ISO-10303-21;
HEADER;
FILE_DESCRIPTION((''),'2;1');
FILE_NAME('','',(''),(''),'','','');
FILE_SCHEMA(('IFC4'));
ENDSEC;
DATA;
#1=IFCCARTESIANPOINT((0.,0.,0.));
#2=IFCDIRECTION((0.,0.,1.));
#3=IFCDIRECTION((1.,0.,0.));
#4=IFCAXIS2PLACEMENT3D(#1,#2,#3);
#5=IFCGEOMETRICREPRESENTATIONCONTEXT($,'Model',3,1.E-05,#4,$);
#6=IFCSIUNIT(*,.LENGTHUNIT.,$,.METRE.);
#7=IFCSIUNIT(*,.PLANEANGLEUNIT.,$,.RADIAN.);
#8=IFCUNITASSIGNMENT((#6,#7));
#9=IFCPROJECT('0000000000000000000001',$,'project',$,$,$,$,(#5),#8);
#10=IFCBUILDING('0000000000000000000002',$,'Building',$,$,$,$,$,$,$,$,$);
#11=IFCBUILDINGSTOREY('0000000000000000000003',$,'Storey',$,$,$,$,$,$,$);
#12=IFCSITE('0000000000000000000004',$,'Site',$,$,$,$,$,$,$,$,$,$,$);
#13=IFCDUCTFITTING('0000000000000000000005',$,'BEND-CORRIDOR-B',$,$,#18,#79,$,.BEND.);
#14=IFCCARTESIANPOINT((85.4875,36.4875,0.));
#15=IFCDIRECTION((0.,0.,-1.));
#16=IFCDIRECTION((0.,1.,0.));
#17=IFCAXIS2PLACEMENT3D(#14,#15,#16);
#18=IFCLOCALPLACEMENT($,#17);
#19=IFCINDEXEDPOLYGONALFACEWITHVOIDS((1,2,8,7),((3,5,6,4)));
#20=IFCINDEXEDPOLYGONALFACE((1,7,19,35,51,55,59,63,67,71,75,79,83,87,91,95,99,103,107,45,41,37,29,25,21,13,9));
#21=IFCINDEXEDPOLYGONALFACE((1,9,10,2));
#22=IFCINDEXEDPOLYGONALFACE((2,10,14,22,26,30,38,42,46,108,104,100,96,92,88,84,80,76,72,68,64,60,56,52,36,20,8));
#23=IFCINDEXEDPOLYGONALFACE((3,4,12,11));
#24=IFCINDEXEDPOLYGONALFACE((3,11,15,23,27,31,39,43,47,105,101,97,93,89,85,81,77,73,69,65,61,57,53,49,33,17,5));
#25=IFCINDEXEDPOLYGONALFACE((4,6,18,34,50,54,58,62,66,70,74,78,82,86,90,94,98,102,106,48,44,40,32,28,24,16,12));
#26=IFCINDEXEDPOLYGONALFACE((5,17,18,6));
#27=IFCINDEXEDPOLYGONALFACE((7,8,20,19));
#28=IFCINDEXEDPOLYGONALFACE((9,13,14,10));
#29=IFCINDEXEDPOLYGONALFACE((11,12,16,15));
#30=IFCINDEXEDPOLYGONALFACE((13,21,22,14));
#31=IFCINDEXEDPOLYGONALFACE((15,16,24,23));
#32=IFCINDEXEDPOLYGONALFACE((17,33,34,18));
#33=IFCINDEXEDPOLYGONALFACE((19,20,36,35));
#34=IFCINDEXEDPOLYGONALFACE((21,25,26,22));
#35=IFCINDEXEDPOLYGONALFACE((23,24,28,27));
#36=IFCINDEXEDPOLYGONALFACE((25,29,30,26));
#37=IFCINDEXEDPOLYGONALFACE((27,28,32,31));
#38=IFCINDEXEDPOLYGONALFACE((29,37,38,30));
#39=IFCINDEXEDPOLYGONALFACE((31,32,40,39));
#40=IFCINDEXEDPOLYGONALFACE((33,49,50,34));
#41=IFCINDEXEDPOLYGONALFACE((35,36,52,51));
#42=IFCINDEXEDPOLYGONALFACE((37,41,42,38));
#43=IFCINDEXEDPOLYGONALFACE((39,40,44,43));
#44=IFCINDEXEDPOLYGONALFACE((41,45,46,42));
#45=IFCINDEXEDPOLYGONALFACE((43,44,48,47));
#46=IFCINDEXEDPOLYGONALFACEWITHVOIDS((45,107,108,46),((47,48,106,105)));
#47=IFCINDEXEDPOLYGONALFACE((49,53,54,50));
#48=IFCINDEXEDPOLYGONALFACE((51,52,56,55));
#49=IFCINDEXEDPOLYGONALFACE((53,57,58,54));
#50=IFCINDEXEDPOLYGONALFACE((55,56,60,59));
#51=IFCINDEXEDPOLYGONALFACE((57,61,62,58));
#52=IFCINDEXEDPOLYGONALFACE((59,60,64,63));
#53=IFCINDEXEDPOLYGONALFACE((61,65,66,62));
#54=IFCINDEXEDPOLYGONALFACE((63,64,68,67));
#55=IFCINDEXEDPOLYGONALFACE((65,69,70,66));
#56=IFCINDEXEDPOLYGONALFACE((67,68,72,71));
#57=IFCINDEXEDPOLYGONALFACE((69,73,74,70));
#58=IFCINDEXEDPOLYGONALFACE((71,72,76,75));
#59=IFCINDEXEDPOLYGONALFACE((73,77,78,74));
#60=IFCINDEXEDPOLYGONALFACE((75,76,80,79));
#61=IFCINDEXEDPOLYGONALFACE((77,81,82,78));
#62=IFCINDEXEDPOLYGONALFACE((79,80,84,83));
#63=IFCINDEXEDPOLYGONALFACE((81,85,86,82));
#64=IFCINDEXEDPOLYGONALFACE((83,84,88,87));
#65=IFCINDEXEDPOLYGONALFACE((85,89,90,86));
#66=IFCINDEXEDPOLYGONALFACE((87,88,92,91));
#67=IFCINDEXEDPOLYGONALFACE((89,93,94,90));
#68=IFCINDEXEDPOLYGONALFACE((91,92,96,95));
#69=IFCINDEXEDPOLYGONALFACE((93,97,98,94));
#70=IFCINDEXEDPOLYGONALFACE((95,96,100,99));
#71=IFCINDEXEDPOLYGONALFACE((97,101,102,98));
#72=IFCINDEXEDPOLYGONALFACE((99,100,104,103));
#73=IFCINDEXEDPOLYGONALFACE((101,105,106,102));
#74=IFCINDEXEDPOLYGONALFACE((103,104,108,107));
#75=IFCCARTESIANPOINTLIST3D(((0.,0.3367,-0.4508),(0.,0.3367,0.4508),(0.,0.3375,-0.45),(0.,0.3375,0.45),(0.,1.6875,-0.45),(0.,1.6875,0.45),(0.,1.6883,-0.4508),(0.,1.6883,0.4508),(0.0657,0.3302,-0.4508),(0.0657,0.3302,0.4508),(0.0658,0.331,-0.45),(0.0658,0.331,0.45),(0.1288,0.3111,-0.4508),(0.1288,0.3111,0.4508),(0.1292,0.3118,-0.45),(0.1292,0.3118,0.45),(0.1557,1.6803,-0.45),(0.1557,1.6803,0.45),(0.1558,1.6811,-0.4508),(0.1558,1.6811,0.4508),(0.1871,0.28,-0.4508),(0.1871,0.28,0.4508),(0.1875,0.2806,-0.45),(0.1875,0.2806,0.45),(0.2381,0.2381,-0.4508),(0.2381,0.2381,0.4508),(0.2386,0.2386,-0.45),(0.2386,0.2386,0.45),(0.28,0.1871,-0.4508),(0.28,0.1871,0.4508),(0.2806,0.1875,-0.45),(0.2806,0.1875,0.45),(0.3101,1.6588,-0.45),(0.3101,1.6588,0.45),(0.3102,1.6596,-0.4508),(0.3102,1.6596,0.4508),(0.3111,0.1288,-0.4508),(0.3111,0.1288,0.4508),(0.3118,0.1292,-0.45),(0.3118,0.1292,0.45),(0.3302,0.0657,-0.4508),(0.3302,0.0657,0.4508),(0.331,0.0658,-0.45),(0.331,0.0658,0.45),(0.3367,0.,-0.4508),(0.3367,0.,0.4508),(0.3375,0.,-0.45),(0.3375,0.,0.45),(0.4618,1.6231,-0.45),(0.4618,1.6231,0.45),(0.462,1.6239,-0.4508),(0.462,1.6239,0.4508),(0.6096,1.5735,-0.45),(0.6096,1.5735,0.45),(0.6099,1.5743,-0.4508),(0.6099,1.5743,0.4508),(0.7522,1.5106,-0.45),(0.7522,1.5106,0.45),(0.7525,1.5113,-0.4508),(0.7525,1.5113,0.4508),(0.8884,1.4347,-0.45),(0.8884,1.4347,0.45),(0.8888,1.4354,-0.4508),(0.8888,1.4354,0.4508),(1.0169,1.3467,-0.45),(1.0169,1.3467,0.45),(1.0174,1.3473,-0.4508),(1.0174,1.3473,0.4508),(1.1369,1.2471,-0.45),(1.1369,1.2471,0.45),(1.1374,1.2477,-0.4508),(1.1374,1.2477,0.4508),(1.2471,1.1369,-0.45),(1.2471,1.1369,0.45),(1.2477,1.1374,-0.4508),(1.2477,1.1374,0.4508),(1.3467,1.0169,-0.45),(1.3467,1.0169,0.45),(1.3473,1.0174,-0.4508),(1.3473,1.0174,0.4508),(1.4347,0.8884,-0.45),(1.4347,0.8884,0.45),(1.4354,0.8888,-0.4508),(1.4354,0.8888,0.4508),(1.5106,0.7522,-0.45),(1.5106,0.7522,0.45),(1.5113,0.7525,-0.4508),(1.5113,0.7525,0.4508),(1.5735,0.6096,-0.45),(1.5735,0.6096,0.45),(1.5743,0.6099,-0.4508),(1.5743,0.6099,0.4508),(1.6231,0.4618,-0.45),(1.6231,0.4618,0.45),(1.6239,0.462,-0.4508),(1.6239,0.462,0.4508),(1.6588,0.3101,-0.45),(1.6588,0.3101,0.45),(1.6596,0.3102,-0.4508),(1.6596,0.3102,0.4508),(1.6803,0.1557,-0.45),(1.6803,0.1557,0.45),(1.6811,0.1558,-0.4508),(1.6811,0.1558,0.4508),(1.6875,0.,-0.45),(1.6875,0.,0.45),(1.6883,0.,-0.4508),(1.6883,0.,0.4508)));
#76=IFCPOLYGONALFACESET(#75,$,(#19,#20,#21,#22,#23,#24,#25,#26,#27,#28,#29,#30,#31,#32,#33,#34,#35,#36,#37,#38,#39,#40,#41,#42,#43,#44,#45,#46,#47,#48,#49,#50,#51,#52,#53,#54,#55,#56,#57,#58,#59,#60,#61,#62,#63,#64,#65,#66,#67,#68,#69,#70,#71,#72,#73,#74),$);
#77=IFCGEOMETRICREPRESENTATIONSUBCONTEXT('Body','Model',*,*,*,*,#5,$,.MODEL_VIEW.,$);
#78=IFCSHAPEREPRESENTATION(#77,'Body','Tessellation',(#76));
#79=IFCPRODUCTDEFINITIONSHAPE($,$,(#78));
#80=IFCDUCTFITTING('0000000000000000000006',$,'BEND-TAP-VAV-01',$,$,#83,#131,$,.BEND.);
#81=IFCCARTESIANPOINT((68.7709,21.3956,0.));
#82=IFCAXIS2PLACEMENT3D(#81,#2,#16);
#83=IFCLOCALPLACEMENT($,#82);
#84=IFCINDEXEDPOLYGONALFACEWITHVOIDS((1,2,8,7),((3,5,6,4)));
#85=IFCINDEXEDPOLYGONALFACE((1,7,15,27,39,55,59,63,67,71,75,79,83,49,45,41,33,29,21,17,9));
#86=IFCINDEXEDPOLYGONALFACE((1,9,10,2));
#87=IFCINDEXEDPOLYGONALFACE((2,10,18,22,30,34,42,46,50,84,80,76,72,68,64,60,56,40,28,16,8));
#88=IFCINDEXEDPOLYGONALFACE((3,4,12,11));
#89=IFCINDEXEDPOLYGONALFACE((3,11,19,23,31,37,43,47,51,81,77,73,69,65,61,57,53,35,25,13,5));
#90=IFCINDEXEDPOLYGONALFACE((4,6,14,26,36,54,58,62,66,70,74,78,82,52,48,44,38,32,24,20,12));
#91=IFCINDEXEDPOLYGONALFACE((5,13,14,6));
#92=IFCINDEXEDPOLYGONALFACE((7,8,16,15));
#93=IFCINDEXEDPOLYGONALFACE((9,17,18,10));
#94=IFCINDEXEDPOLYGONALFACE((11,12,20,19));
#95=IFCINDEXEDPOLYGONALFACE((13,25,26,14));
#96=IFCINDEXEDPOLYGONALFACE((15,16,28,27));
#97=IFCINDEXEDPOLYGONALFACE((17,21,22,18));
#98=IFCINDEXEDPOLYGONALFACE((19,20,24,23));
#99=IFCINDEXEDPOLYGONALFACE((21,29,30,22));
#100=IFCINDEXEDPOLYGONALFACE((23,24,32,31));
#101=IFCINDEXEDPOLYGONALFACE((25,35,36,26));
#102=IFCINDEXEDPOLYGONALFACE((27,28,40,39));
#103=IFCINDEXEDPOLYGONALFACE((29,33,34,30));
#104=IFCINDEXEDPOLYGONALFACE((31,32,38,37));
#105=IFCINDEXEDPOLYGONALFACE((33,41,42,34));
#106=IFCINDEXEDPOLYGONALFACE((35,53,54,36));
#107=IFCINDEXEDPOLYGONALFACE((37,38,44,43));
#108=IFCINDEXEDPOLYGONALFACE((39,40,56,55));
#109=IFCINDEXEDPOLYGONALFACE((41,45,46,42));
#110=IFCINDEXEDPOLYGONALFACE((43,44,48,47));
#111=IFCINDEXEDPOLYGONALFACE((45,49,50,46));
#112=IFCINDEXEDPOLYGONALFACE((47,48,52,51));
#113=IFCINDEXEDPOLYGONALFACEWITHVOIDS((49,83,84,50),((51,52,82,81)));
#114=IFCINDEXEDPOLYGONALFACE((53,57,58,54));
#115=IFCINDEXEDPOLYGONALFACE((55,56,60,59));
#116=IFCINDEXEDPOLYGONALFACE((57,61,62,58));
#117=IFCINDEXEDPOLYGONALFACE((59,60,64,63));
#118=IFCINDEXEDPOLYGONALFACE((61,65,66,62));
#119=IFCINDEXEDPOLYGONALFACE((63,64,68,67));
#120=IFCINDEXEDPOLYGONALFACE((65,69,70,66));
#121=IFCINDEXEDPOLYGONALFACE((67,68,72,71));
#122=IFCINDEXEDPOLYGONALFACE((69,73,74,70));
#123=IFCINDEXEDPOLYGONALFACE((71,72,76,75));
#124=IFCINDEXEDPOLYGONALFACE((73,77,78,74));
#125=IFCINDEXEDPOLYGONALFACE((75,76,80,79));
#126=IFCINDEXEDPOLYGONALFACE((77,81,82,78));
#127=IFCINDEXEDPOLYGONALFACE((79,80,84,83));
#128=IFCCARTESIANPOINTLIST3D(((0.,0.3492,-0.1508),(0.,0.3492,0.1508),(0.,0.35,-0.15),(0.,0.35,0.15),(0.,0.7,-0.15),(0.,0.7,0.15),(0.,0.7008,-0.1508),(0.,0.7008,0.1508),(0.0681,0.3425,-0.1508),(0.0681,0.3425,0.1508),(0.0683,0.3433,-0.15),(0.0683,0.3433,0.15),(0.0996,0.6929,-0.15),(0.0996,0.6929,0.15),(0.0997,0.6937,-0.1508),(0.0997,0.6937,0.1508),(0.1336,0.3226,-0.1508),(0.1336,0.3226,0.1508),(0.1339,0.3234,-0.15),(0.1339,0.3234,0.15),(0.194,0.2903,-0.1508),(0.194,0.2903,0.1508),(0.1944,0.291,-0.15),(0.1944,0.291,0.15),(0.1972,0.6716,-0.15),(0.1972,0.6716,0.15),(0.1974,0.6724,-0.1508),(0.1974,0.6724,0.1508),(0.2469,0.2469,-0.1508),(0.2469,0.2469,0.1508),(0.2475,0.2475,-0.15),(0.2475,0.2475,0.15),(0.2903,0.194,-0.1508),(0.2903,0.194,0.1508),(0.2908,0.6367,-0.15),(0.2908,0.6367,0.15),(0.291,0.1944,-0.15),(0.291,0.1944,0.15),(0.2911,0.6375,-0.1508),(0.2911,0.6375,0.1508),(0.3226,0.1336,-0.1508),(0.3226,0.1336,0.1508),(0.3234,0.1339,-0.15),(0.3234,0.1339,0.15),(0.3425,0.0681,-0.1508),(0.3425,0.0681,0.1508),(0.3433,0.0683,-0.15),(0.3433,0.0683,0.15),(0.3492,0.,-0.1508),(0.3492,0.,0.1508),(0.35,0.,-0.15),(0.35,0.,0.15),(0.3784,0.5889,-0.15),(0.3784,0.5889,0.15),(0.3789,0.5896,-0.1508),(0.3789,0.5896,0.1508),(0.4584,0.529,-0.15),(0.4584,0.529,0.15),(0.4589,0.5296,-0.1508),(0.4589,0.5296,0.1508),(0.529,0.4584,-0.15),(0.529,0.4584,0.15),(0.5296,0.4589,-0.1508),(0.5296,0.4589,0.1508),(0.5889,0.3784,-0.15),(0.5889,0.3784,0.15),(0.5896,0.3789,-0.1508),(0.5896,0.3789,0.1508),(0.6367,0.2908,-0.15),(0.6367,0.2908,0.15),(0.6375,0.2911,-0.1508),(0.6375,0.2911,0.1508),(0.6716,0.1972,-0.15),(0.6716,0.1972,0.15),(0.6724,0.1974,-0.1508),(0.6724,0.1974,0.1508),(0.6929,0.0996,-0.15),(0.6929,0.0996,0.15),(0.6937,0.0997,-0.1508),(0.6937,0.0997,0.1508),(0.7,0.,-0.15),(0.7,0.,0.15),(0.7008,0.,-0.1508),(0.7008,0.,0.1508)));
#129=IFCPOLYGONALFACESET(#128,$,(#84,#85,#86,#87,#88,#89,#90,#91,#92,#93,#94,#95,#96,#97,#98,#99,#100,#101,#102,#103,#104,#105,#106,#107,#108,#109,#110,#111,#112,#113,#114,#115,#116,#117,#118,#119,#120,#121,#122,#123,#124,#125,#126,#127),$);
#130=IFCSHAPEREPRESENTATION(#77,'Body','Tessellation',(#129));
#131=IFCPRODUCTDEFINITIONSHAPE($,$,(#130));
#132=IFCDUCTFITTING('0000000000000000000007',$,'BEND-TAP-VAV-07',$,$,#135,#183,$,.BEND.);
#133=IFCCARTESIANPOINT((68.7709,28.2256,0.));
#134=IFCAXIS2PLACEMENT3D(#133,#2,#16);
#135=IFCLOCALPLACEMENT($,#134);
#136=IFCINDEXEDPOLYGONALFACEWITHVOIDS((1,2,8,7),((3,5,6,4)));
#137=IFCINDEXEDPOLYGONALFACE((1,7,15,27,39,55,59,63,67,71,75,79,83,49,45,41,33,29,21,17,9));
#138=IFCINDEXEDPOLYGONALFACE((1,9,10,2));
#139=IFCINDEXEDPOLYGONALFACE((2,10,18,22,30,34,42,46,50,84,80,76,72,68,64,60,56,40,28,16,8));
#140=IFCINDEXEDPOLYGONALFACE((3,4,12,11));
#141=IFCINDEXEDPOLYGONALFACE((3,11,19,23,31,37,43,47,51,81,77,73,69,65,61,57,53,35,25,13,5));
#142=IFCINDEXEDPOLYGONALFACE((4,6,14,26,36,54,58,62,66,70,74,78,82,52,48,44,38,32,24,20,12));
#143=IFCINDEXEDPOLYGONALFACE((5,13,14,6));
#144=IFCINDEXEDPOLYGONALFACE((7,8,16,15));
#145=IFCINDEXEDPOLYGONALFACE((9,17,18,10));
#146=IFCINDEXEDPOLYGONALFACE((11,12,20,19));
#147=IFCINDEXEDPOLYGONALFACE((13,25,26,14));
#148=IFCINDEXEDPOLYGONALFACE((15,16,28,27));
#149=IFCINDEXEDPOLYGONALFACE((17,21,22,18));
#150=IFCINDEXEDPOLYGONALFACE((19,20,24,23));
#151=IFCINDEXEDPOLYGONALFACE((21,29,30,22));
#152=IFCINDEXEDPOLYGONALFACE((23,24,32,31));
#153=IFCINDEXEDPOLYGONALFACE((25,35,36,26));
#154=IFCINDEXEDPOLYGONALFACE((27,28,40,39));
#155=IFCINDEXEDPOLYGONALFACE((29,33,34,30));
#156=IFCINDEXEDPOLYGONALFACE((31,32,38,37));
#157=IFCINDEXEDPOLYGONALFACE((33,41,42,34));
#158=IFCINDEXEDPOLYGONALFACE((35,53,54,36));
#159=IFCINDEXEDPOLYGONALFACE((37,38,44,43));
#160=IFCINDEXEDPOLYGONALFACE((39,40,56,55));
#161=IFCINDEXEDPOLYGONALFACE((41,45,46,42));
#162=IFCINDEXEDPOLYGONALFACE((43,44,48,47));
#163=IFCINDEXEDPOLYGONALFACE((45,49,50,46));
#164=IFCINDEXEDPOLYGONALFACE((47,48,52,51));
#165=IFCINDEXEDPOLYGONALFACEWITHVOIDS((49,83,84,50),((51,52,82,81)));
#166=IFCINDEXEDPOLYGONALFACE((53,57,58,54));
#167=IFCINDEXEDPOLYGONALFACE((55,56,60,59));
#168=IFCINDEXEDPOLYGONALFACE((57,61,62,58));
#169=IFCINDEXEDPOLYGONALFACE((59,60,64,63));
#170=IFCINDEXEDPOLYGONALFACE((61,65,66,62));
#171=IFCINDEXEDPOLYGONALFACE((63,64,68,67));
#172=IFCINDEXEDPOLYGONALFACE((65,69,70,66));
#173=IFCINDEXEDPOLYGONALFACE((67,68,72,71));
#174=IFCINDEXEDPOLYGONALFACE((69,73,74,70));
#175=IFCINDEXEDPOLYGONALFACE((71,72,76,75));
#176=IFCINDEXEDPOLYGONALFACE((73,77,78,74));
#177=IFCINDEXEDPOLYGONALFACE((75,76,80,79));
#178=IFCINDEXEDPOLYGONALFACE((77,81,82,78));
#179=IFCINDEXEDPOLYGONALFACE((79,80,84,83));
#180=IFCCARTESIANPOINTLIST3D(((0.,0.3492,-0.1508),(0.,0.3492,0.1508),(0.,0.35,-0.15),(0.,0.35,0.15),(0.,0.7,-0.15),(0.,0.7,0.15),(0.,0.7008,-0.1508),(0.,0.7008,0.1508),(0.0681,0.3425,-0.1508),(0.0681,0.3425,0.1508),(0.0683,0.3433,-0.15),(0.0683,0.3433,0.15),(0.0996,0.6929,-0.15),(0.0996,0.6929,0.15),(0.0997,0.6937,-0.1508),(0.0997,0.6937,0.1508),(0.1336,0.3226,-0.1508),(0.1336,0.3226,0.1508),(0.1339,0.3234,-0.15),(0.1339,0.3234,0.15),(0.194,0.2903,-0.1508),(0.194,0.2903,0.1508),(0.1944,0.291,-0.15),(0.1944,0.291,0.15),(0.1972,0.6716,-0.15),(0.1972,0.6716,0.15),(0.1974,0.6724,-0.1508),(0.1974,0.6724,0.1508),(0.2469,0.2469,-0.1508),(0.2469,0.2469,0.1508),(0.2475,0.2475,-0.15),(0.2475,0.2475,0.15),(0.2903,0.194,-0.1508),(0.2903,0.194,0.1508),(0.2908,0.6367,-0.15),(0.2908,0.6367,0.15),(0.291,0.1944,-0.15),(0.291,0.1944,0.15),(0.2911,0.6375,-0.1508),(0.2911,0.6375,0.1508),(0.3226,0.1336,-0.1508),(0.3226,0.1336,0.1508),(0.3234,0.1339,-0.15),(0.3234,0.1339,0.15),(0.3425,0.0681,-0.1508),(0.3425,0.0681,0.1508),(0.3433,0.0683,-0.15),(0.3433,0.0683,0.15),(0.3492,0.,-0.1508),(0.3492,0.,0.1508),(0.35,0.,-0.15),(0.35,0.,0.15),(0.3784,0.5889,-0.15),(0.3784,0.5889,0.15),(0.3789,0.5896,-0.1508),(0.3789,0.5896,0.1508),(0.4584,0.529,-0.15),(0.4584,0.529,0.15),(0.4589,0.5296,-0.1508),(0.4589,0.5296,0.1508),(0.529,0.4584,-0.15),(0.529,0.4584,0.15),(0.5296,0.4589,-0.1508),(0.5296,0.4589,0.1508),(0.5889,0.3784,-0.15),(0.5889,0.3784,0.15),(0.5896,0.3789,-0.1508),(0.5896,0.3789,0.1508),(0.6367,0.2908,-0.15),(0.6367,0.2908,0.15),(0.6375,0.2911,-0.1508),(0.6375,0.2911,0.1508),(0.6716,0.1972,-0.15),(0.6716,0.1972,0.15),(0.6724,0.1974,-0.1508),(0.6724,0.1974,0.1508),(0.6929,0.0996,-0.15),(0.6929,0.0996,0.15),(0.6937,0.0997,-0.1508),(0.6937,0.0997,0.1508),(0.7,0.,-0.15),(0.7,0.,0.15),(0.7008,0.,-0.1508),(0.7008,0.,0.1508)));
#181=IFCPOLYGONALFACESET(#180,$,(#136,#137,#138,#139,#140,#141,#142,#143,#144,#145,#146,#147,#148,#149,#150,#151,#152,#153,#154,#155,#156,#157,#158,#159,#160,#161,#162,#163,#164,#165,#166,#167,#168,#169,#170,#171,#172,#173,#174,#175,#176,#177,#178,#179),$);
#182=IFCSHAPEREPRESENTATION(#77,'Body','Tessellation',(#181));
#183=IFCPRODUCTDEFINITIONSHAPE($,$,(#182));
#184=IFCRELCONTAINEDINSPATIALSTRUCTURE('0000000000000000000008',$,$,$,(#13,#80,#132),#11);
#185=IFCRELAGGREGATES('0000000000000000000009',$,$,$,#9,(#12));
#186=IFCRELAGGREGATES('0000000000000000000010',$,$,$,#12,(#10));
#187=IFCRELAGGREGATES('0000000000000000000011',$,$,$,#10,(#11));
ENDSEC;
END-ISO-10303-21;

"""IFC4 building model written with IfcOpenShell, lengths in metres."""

from ifc_helpers import new_model, entity, si_unit, frame, origin_with_axes, place, context, subcontext, project, spatial, element, save


model = new_model("IFC4")

# Units and contexts
model_context = context("Model", 3, precision=1e-05, world=origin_with_axes())
body_context = subcontext(model_context, "Body", "Model", "MODEL_VIEW")
ifc_project = project(units=[si_unit("LENGTHUNIT", "METRE"), si_unit("PLANEANGLEUNIT", "RADIAN")], contexts=[model_context])

# Site, building, storey
site = spatial("IfcSite", under=ifc_project, Name="Site")
building = spatial("IfcBuilding", under=site, Name="Building")
storey = spatial("IfcBuildingStorey", under=building, Name="Storey")

# Duct fittings
duct_fitting_1_placement = place(None, frame((85.4875, 36.4875, 0.0), z_axis=(0.0, 0.0, -1.0), x_axis=(0.0, 1.0, 0.0)))
cartesian_point_1 = entity("IfcCartesianPoint", [0.0, 0.0, 0.0])
element("IfcDuctFitting", 1, at=duct_fitting_1_placement, inside=storey, Name="BEND-CORRIDOR-B", PredefinedType="BEND", context=body_context, shape_type="SweptSolid", body=[
    entity("IfcRevolvedAreaSolid", entity("IfcRectangleHollowProfileDef", "AREA", None, entity("IfcAxis2Placement2D", entity("IfcCartesianPoint", [1.0125, 0.0])), 1.3516, 0.9016, 0.0008), entity("IfcAxis2Placement3D", cartesian_point_1, entity("IfcDirection", [0.0, -1.0, 0.0]), entity("IfcDirection", [1.0, 0.0, 0.0])), entity("IfcAxis1Placement", cartesian_point_1, entity("IfcDirection", [0.0, 1.0, 0.0])), 1.570796),
])
duct_fitting_2_placement = place(None, frame((68.7709, 21.3956, 0.0), z_axis=(0.0, 0.0, 1.0), x_axis=(0.0, 1.0, 0.0)))
cartesian_point_2 = entity("IfcCartesianPoint", [0.0, 0.0, 0.0])
element("IfcDuctFitting", 2, at=duct_fitting_2_placement, inside=storey, Name="BEND-TAP-VAV-01", PredefinedType="BEND", context=body_context, shape_type="SweptSolid", body=[
    entity("IfcRevolvedAreaSolid", entity("IfcRectangleHollowProfileDef", "AREA", None, entity("IfcAxis2Placement2D", entity("IfcCartesianPoint", [0.525, 0.0])), 0.3516, 0.3016, 0.0008), entity("IfcAxis2Placement3D", cartesian_point_2, entity("IfcDirection", [0.0, -1.0, 0.0]), entity("IfcDirection", [1.0, 0.0, 0.0])), entity("IfcAxis1Placement", cartesian_point_2, entity("IfcDirection", [0.0, 1.0, 0.0])), 1.570796),
])
duct_fitting_3_placement = place(None, frame((68.7709, 28.2256, 0.0), z_axis=(0.0, 0.0, 1.0), x_axis=(0.0, 1.0, 0.0)))
cartesian_point_3 = entity("IfcCartesianPoint", [0.0, 0.0, 0.0])
element("IfcDuctFitting", 3, at=duct_fitting_3_placement, inside=storey, Name="BEND-TAP-VAV-07", PredefinedType="BEND", context=body_context, shape_type="SweptSolid", body=[
    entity("IfcRevolvedAreaSolid", entity("IfcRectangleHollowProfileDef", "AREA", None, entity("IfcAxis2Placement2D", entity("IfcCartesianPoint", [0.525, 0.0])), 0.3516, 0.3016, 0.0008), entity("IfcAxis2Placement3D", cartesian_point_3, entity("IfcDirection", [0.0, -1.0, 0.0]), entity("IfcDirection", [1.0, 0.0, 0.0])), entity("IfcAxis1Placement", cartesian_point_3, entity("IfcDirection", [0.0, 1.0, 0.0])), 1.570796),
])

save(model, "model.ifc")
